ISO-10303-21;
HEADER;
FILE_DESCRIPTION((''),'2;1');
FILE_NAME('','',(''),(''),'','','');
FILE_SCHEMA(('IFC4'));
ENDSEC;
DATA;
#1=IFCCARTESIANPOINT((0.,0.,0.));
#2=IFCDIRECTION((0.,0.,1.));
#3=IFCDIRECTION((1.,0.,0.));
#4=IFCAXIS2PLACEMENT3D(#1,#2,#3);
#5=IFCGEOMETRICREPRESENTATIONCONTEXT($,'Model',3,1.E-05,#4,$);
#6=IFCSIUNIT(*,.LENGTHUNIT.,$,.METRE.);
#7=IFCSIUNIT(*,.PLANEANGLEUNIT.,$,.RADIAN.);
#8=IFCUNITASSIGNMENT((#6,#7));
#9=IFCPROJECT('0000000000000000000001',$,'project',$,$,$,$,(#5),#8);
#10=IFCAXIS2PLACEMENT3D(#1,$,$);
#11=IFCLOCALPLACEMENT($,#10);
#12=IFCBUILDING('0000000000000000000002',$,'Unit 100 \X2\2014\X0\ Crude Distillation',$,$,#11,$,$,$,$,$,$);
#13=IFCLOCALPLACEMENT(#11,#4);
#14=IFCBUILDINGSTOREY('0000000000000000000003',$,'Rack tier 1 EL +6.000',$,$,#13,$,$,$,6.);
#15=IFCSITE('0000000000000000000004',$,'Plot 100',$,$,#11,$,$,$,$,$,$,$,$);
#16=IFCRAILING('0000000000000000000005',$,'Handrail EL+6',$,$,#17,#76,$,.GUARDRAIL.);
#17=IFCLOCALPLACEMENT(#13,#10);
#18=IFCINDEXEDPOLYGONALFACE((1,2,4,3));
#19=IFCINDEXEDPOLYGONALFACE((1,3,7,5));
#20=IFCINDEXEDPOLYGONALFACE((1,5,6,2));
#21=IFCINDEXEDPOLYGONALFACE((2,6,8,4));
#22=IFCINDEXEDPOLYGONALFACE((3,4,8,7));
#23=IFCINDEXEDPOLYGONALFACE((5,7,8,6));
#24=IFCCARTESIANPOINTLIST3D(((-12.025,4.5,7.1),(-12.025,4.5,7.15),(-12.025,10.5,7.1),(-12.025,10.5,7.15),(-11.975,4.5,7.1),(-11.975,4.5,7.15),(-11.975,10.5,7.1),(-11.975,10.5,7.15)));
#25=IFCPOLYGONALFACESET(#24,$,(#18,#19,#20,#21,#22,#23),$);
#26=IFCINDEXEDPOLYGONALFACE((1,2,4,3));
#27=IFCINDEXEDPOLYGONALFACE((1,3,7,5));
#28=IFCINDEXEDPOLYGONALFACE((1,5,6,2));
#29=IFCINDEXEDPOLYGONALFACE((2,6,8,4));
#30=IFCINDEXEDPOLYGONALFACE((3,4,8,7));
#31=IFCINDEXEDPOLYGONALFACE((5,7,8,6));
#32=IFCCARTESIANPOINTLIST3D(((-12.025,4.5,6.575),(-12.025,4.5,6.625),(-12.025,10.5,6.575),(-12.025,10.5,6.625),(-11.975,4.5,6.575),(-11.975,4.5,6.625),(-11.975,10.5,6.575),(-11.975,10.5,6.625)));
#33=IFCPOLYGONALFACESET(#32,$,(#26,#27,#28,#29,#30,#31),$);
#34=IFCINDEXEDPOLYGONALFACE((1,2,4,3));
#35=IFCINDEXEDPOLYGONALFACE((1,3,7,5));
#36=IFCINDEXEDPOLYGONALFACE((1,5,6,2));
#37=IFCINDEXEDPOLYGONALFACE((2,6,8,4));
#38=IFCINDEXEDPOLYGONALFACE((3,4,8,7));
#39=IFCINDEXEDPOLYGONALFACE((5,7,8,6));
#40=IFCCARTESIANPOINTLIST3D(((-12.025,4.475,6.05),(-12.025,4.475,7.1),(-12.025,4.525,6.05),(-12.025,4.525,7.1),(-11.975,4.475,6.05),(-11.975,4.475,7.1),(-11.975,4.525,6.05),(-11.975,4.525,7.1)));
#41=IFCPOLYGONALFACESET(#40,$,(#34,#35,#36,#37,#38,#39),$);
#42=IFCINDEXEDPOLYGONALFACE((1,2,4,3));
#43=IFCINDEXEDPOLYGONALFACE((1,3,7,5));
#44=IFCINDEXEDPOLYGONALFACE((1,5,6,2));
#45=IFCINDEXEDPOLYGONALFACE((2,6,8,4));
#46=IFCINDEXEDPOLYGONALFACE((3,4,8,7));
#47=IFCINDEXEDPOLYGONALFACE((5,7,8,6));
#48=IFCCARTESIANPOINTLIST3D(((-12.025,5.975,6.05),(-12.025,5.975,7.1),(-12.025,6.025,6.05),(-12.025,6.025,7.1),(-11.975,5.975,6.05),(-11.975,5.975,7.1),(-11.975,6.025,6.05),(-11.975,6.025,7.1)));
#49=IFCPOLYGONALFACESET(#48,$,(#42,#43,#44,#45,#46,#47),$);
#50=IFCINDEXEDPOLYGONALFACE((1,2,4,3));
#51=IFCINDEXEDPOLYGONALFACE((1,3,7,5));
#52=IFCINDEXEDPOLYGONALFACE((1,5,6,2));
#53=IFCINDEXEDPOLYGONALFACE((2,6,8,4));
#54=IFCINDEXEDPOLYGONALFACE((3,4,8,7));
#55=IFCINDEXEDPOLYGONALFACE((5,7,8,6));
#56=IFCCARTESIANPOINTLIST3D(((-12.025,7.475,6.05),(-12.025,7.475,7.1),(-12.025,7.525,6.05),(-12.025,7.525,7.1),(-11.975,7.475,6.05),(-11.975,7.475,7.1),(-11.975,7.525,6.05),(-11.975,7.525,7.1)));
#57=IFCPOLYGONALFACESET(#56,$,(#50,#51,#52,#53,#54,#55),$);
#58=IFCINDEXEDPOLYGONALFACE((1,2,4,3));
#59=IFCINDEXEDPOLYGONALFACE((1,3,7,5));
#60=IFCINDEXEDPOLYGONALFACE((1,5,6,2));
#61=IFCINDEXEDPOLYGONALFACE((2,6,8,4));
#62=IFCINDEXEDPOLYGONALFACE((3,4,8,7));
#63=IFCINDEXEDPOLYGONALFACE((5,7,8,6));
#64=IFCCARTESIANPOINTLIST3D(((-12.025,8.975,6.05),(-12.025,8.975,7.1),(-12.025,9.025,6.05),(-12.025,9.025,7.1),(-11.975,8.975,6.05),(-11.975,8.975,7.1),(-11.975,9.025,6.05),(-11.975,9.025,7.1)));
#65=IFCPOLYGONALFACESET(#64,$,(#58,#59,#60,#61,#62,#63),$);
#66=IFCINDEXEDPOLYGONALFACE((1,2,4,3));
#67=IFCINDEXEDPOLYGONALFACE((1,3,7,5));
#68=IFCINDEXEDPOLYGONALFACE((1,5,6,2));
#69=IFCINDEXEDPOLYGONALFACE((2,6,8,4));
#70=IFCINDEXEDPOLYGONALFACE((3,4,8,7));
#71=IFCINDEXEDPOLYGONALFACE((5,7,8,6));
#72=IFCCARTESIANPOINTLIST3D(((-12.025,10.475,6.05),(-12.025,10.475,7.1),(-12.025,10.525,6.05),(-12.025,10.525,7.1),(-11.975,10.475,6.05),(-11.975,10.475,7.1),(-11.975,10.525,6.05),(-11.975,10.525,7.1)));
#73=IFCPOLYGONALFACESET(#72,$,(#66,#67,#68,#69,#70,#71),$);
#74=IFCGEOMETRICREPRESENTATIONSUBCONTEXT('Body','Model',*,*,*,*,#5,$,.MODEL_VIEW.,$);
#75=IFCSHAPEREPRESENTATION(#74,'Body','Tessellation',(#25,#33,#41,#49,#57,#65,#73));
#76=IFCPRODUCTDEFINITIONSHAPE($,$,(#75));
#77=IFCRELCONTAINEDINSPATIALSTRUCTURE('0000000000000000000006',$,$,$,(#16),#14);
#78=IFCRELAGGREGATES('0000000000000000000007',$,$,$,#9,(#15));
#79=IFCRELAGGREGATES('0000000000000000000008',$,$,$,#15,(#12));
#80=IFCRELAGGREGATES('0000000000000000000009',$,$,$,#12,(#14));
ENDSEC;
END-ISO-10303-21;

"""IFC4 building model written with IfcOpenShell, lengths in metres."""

from ifc_helpers import new_model, si_unit, frame, origin, origin_with_axes, origin_2d, place, context, subcontext, project, spatial, rectangle, extrude, element, save


model = new_model("IFC4")

# Units and contexts
model_context = context("Model", 3, precision=1e-05, world=origin_with_axes())
body_context = subcontext(model_context, "Body", "Model", "MODEL_VIEW")
ifc_project = project(units=[si_unit("LENGTHUNIT", "METRE"), si_unit("PLANEANGLEUNIT", "RADIAN")], contexts=[model_context])

# Site, building, storey
placement = place(None, origin())
site = spatial("IfcSite", under=ifc_project, at=placement, Name="Plot 100")
building = spatial("IfcBuilding", under=site, at=placement, Name="Unit 100 — Crude Distillation")
storey_placement = place(placement, origin_with_axes())
storey = spatial("IfcBuildingStorey", under=building, at=storey_placement, Name="Rack tier 1 EL +6.000", Elevation=6.0)

# Railing
railing_1_placement = place(storey_placement, origin_with_axes())
element("IfcRailing", 1, at=railing_1_placement, inside=storey, Name="Handrail EL+6", PredefinedType="GUARDRAIL", context=body_context, shape_type="SweptSolid", body=[
    extrude(rectangle(XDim=0.05, YDim=0.05, at=origin_2d()), frame((-12.0, 4.5, 7.125), z_axis=(0.0, 1.0, 0.0), x_axis=(-1.0, 0.0, 0.0)), (0.0, 0.0, 1.0), 6.0),
    extrude(rectangle(XDim=0.05, YDim=0.05, at=origin_2d()), frame((-12.0, 4.5, 6.6), z_axis=(0.0, 1.0, 0.0), x_axis=(-1.0, 0.0, 0.0)), (0.0, 0.0, 1.0), 6.0),
    extrude(rectangle(XDim=0.05, YDim=0.05, at=origin_2d()), frame((-12.0, 4.5, 6.05), z_axis=(0.0, 0.0, 1.0), x_axis=(1.0, 0.0, 0.0)), (0.0, 0.0, 1.0), 1.05),
    extrude(rectangle(XDim=0.05, YDim=0.05, at=origin_2d()), frame((-12.0, 6.0, 6.05), z_axis=(0.0, 0.0, 1.0), x_axis=(1.0, 0.0, 0.0)), (0.0, 0.0, 1.0), 1.05),
    extrude(rectangle(XDim=0.05, YDim=0.05, at=origin_2d()), frame((-12.0, 7.5, 6.05), z_axis=(0.0, 0.0, 1.0), x_axis=(1.0, 0.0, 0.0)), (0.0, 0.0, 1.0), 1.05),
    extrude(rectangle(XDim=0.05, YDim=0.05, at=origin_2d()), frame((-12.0, 9.0, 6.05), z_axis=(0.0, 0.0, 1.0), x_axis=(1.0, 0.0, 0.0)), (0.0, 0.0, 1.0), 1.05),
    extrude(rectangle(XDim=0.05, YDim=0.05, at=origin_2d()), frame((-12.0, 10.5, 6.05), z_axis=(0.0, 0.0, 1.0), x_axis=(1.0, 0.0, 0.0)), (0.0, 0.0, 1.0), 1.05),
])

save(model, "model.ifc")
